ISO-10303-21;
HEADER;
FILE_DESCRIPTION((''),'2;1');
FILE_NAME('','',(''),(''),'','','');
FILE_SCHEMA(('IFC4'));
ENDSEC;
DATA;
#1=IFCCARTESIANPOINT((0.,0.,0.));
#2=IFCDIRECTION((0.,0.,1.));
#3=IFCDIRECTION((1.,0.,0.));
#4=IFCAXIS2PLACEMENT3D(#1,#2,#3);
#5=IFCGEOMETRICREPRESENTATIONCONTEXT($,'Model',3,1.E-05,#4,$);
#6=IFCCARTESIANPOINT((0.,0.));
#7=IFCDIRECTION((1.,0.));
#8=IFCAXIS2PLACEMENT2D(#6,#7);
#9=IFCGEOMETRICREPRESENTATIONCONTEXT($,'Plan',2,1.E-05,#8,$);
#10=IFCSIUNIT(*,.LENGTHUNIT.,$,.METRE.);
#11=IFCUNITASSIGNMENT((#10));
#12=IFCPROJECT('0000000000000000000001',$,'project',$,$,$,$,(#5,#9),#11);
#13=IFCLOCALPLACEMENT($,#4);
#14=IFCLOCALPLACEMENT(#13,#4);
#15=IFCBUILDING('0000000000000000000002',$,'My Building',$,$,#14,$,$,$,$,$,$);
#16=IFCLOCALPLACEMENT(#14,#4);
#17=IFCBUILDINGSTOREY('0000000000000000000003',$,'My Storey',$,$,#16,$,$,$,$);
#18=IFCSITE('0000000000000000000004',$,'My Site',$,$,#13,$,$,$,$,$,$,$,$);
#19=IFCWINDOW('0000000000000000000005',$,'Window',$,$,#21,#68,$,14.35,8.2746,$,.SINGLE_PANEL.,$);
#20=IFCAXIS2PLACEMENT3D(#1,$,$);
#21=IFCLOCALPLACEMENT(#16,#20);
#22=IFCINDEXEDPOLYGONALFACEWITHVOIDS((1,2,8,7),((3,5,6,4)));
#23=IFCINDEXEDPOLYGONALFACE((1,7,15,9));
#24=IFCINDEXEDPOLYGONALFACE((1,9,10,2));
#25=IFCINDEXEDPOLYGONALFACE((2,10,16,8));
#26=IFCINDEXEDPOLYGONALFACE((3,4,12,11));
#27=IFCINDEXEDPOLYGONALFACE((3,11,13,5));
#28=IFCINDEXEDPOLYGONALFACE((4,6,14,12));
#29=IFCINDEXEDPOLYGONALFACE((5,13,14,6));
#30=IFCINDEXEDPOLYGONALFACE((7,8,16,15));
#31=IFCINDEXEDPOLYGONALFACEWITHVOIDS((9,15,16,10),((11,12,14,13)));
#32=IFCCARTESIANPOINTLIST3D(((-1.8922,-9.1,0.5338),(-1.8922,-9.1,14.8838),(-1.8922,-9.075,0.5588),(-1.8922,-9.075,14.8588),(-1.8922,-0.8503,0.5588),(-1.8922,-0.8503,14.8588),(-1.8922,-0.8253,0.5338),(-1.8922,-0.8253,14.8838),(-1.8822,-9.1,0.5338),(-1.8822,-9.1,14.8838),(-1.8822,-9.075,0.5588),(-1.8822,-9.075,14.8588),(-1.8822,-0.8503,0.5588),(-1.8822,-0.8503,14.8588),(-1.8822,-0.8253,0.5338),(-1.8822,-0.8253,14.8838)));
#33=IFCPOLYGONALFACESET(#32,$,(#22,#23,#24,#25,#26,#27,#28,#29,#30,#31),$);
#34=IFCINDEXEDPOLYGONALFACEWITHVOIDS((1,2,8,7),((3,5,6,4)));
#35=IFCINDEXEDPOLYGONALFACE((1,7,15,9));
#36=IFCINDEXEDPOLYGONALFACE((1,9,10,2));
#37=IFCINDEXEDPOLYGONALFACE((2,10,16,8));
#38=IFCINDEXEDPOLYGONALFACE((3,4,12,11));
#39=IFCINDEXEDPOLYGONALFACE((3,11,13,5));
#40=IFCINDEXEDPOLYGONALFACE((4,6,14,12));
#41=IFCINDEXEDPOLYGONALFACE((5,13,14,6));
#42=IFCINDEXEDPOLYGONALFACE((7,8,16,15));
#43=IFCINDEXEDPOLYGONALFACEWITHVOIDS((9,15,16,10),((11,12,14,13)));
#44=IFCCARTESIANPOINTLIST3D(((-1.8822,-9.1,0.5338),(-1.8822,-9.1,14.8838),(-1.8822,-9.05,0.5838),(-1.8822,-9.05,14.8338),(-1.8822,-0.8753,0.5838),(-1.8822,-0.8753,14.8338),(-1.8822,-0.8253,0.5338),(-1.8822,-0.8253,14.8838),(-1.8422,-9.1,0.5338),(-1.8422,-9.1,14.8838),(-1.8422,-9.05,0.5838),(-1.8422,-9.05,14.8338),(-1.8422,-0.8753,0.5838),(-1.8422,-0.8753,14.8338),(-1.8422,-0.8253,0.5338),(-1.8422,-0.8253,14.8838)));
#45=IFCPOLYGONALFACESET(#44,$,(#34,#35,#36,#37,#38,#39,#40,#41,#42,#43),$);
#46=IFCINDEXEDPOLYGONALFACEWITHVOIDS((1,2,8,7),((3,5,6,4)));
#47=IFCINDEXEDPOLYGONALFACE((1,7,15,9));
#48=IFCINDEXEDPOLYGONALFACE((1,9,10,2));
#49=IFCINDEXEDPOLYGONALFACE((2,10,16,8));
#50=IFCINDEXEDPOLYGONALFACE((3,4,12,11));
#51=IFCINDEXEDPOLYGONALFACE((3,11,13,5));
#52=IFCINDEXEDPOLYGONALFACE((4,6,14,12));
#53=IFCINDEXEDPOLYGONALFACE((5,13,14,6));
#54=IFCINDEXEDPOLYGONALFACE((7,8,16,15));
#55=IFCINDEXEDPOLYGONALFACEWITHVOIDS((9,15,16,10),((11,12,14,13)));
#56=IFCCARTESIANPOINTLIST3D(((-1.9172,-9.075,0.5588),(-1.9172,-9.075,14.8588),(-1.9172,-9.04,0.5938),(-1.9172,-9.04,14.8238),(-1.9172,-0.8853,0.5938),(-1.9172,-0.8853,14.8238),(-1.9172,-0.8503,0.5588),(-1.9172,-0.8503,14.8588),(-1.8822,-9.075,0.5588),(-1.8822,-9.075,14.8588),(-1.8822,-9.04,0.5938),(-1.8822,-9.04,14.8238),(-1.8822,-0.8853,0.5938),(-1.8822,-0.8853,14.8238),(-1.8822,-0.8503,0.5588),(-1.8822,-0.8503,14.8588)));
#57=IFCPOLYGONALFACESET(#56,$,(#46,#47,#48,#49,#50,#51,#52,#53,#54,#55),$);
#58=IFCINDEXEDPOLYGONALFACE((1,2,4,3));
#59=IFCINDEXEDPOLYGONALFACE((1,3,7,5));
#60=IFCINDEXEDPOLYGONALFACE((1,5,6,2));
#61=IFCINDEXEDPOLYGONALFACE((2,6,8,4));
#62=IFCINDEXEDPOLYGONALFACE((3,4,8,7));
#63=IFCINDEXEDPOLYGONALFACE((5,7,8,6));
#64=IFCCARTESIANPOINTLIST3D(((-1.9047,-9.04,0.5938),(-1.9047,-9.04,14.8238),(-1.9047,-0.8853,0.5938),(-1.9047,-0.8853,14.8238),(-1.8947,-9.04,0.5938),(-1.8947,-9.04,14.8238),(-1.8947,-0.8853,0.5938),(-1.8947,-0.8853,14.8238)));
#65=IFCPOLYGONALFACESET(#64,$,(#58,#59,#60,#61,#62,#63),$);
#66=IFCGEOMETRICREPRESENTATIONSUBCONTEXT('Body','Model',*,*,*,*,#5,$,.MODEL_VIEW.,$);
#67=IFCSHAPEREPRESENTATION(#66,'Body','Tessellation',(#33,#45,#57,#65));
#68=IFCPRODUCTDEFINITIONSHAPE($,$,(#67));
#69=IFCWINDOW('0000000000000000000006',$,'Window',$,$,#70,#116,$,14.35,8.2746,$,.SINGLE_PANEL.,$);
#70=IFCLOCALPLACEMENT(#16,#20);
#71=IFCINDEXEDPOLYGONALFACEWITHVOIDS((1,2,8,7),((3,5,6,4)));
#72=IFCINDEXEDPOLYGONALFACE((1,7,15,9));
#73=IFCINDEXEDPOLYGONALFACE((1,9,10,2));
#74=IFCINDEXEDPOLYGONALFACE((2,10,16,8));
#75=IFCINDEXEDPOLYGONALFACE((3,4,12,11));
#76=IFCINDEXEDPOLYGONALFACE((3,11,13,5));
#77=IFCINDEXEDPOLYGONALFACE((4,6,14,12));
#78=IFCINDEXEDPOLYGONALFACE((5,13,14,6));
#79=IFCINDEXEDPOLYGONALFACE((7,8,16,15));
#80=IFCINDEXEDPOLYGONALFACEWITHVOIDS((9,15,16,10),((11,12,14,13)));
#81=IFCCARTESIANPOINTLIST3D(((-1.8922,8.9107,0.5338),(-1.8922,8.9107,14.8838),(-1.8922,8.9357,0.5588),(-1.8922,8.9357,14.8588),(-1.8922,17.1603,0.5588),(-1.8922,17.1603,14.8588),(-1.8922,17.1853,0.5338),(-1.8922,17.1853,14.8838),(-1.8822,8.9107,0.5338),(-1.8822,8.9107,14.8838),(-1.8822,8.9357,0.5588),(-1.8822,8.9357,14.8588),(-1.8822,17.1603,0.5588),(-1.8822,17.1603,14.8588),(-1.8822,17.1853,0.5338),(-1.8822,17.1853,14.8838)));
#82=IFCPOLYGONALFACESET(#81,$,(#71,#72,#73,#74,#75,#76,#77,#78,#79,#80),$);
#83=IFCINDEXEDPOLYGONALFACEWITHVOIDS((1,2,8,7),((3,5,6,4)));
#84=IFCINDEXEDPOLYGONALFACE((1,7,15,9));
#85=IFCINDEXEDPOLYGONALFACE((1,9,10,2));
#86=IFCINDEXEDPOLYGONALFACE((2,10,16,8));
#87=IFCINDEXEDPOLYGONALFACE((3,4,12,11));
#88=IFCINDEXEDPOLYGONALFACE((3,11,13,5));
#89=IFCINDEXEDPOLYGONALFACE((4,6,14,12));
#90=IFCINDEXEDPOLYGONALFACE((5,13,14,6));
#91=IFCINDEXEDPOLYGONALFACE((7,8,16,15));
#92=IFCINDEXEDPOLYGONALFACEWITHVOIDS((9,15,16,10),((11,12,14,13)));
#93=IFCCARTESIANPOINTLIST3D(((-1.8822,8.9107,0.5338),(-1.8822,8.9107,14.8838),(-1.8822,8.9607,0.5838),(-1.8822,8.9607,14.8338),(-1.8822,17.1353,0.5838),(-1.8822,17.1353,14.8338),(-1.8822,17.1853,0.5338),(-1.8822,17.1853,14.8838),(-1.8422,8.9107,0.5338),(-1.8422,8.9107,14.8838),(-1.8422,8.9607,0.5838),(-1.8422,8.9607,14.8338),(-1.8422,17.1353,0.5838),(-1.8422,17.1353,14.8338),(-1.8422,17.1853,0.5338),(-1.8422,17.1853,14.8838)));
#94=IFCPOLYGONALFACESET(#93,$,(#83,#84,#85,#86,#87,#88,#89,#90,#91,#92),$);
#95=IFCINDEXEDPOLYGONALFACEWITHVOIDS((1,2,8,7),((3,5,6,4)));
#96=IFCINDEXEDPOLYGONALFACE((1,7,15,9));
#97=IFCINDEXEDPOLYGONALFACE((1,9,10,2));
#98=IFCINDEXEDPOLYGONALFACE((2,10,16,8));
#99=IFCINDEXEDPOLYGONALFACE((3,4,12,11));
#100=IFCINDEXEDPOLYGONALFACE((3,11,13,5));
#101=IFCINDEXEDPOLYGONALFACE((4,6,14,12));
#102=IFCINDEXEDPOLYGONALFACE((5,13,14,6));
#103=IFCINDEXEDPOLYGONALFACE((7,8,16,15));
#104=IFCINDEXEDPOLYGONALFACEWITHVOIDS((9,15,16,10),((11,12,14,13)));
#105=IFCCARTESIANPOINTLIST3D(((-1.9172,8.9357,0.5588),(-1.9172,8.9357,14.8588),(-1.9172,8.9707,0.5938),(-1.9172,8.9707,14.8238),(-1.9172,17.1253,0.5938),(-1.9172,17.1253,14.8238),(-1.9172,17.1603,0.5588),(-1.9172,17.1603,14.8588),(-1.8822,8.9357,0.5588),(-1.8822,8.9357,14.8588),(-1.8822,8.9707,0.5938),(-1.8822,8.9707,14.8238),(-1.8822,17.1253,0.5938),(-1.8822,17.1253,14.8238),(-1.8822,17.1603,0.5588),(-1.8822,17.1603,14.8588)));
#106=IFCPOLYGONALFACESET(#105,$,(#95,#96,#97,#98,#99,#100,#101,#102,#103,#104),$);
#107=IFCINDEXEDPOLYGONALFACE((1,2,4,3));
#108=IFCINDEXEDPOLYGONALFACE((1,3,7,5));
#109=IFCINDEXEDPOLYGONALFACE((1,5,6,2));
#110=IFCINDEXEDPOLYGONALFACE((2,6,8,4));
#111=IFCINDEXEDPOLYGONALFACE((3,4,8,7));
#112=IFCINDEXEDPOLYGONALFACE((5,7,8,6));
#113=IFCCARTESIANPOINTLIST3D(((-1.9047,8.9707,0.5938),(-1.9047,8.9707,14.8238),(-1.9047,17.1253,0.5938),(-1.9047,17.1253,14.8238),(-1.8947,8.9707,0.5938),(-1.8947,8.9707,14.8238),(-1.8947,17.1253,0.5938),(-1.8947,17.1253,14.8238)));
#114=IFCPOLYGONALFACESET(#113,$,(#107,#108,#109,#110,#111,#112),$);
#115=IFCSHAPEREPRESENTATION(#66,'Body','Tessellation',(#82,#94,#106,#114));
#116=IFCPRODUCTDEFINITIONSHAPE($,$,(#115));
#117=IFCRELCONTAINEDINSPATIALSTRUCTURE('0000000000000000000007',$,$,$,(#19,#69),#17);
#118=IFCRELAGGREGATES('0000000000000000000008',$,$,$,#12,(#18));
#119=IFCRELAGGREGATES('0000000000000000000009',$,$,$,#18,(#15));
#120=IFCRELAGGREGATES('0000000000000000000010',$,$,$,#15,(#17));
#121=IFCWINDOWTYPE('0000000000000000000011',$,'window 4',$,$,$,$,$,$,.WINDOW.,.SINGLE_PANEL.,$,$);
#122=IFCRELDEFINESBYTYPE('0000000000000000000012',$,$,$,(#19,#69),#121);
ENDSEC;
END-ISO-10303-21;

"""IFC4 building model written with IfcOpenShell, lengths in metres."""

from ifc_helpers import new_model, entity, si_unit, frame, origin_with_axes, origin_2d_with_axis, place, context, subcontext, project, spatial, line, indexed_curve, outline, extrude, shape, source, transform, mapped, type_object, type_shapes, element, save


model = new_model("IFC4")

# Units and contexts
model_context = context("Model", 3, precision=1e-05, world=origin_with_axes())
plan_context = context("Plan", 2, precision=1e-05, world=origin_2d_with_axis())
body_context_1 = subcontext(model_context, "Body", "Model", "MODEL_VIEW")
body_context_2 = subcontext(plan_context, "Body", "Plan", "PLAN_VIEW")
ifc_project = project(units=[si_unit("LENGTHUNIT", "METRE")], contexts=[model_context, plan_context])

# Site, building, storey
site_placement = place(None, origin_with_axes())
site = spatial("IfcSite", under=ifc_project, at=site_placement, Name="My Site")
building_placement = place(site_placement, origin_with_axes())
building = spatial("IfcBuilding", under=site, at=building_placement, Name="My Building")
storey_placement = place(building_placement, origin_with_axes())
storey = spatial("IfcBuildingStorey", under=building, at=storey_placement, Name="My Storey")

# Windows
window_type_1 = type_object("IfcWindowType", Name="window 4", PartitioningType="SINGLE_PANEL", PredefinedType="WINDOW")
shared_shape_1 = source(origin_with_axes(), body_context_1, "Body", "SweptSolid", [
    extrude(outline(indexed_curve([(0.0, 0.0), (8.2746, 0.0), (8.2746, 14.35), (0.0, 14.35)], segments=[line(1, 2, 3, 4, 1)]), holes=[indexed_curve([(0.025, 0.025), (8.2496, 0.025), (8.2496, 14.325), (0.025, 14.325)], segments=[line(1, 2, 3, 4, 1)])]), frame((0.0, 0.09, 0.0), z_axis=(0.0, -1.0, 0.0), x_axis=(1.0, 0.0, 0.0)), (0.0, 0.0, -1.0), 0.01),
    extrude(outline(indexed_curve([(0.0, 0.0), (8.2746, 0.0), (8.2746, 14.35), (0.0, 14.35)], segments=[line(1, 2, 3, 4, 1)]), holes=[indexed_curve([(0.05, 0.05), (8.2246, 0.05), (8.2246, 14.3), (0.05, 14.3)], segments=[line(1, 2, 3, 4, 1)])]), frame((0.0, 0.05, 0.0), z_axis=(0.0, -1.0, 0.0), x_axis=(1.0, 0.0, 0.0)), (0.0, 0.0, -1.0), 0.04),
    extrude(outline(indexed_curve([(0.0, 0.0), (8.2246, 0.0), (8.2246, 14.3), (0.0, 14.3)], segments=[line(1, 2, 3, 4, 1)]), holes=[indexed_curve([(0.035, 0.035), (8.1896, 0.035), (8.1896, 14.265), (0.035, 14.265)], segments=[line(1, 2, 3, 4, 1)])]), frame((0.025, 0.09, 0.025), z_axis=(0.0, -1.0, 0.0), x_axis=(1.0, 0.0, 0.0)), (0.0, 0.0, -1.0), 0.035),
    extrude(outline(indexed_curve([(0.035, 0.035), (8.1896, 0.035), (8.1896, 14.265), (0.035, 14.265)], segments=[line(1, 2, 3, 4, 1)])), frame((0.025, 0.1025, 0.025), z_axis=(0.0, -1.0, 0.0), x_axis=(1.0, 0.0, 0.0)), (0.0, 0.0, -1.0), 0.01),
])
shared_shape_2 = source(origin_with_axes(), body_context_2, "Body", "Curve2D", [
    entity("IfcIndexedPolyCurve", entity("IfcCartesianPointList2D", [[0.05, 0.05], [8.2246, 0.05]])),
    entity("IfcIndexedPolyCurve", entity("IfcCartesianPointList2D", [[0.0, 0.1], [0.025, 0.1], [0.025, 0.09], [0.05, 0.09], [0.05, 0.05], [0.0, 0.05]]), [entity("IfcLineIndex", [1, 2, 3, 4, 5, 6, 1])]),
    entity("IfcIndexedPolyCurve", entity("IfcCartesianPointList2D", [[8.2746, 0.1], [8.2496, 0.1], [8.2496, 0.09], [8.2246, 0.09], [8.2246, 0.05], [8.2746, 0.05]]), [entity("IfcLineIndex", [1, 2, 3, 4, 5, 6, 1])]),
    entity("IfcIndexedPolyCurve", entity("IfcCartesianPointList2D", [[0.025, 0.09], [0.06, 0.09], [0.06, 0.125], [0.025, 0.125]]), [entity("IfcLineIndex", [1, 2, 3, 4, 1])]),
    entity("IfcIndexedPolyCurve", entity("IfcCartesianPointList2D", [[8.2496, 0.09], [8.2146, 0.09], [8.2146, 0.125], [8.2496, 0.125]]), [entity("IfcLineIndex", [1, 2, 3, 4, 1])]),
    entity("IfcIndexedPolyCurve", entity("IfcCartesianPointList2D", [[0.06, 0.09], [8.2146, 0.09]])),
    entity("IfcIndexedPolyCurve", entity("IfcCartesianPointList2D", [[0.06, 0.125], [8.2146, 0.125]])),
    entity("IfcIndexedPolyCurve", entity("IfcCartesianPointList2D", [[0.06, 0.1075], [8.2146, 0.1075]])),
])
type_shapes(window_type_1, [shared_shape_1, shared_shape_2])
for number, where, z_axis, x_axis, name in (
    (1, (-1.7922, -9.1, 0.5338), (0.0, 0.0, 1.0), (0.0, 1.0, 0.0), "Window"),
    (2, (-1.7922, 8.9107, 0.5338), (0.0, 0.0, 1.0), (0.0, 1.0, 0.0), "Window"),
):
    element("IfcWindow", number, at=place(storey_placement, frame(where, z_axis=z_axis, x_axis=x_axis)), inside=storey, type_object=window_type_1, Name=name, OverallHeight=14.35, OverallWidth=8.2746, PartitioningType="SINGLE_PANEL", shapes=[
        shape(body_context_1, "Body", "MappedRepresentation", [mapped(shared_shape_1, transform((0.0, 0.0, 0.0), x_axis=(1.0, 0.0, 0.0), y_axis=(0.0, 1.0, 0.0), z_axis=(0.0, 0.0, 1.0), scale=1.0))]),
        shape(body_context_2, "Body", "MappedRepresentation", [mapped(shared_shape_2, transform((0.0, 0.0, 0.0), x_axis=(1.0, 0.0, 0.0), y_axis=(0.0, 1.0, 0.0), z_axis=(0.0, 0.0, 1.0), scale=1.0))]),
    ])

save(model, "model.ifc")
